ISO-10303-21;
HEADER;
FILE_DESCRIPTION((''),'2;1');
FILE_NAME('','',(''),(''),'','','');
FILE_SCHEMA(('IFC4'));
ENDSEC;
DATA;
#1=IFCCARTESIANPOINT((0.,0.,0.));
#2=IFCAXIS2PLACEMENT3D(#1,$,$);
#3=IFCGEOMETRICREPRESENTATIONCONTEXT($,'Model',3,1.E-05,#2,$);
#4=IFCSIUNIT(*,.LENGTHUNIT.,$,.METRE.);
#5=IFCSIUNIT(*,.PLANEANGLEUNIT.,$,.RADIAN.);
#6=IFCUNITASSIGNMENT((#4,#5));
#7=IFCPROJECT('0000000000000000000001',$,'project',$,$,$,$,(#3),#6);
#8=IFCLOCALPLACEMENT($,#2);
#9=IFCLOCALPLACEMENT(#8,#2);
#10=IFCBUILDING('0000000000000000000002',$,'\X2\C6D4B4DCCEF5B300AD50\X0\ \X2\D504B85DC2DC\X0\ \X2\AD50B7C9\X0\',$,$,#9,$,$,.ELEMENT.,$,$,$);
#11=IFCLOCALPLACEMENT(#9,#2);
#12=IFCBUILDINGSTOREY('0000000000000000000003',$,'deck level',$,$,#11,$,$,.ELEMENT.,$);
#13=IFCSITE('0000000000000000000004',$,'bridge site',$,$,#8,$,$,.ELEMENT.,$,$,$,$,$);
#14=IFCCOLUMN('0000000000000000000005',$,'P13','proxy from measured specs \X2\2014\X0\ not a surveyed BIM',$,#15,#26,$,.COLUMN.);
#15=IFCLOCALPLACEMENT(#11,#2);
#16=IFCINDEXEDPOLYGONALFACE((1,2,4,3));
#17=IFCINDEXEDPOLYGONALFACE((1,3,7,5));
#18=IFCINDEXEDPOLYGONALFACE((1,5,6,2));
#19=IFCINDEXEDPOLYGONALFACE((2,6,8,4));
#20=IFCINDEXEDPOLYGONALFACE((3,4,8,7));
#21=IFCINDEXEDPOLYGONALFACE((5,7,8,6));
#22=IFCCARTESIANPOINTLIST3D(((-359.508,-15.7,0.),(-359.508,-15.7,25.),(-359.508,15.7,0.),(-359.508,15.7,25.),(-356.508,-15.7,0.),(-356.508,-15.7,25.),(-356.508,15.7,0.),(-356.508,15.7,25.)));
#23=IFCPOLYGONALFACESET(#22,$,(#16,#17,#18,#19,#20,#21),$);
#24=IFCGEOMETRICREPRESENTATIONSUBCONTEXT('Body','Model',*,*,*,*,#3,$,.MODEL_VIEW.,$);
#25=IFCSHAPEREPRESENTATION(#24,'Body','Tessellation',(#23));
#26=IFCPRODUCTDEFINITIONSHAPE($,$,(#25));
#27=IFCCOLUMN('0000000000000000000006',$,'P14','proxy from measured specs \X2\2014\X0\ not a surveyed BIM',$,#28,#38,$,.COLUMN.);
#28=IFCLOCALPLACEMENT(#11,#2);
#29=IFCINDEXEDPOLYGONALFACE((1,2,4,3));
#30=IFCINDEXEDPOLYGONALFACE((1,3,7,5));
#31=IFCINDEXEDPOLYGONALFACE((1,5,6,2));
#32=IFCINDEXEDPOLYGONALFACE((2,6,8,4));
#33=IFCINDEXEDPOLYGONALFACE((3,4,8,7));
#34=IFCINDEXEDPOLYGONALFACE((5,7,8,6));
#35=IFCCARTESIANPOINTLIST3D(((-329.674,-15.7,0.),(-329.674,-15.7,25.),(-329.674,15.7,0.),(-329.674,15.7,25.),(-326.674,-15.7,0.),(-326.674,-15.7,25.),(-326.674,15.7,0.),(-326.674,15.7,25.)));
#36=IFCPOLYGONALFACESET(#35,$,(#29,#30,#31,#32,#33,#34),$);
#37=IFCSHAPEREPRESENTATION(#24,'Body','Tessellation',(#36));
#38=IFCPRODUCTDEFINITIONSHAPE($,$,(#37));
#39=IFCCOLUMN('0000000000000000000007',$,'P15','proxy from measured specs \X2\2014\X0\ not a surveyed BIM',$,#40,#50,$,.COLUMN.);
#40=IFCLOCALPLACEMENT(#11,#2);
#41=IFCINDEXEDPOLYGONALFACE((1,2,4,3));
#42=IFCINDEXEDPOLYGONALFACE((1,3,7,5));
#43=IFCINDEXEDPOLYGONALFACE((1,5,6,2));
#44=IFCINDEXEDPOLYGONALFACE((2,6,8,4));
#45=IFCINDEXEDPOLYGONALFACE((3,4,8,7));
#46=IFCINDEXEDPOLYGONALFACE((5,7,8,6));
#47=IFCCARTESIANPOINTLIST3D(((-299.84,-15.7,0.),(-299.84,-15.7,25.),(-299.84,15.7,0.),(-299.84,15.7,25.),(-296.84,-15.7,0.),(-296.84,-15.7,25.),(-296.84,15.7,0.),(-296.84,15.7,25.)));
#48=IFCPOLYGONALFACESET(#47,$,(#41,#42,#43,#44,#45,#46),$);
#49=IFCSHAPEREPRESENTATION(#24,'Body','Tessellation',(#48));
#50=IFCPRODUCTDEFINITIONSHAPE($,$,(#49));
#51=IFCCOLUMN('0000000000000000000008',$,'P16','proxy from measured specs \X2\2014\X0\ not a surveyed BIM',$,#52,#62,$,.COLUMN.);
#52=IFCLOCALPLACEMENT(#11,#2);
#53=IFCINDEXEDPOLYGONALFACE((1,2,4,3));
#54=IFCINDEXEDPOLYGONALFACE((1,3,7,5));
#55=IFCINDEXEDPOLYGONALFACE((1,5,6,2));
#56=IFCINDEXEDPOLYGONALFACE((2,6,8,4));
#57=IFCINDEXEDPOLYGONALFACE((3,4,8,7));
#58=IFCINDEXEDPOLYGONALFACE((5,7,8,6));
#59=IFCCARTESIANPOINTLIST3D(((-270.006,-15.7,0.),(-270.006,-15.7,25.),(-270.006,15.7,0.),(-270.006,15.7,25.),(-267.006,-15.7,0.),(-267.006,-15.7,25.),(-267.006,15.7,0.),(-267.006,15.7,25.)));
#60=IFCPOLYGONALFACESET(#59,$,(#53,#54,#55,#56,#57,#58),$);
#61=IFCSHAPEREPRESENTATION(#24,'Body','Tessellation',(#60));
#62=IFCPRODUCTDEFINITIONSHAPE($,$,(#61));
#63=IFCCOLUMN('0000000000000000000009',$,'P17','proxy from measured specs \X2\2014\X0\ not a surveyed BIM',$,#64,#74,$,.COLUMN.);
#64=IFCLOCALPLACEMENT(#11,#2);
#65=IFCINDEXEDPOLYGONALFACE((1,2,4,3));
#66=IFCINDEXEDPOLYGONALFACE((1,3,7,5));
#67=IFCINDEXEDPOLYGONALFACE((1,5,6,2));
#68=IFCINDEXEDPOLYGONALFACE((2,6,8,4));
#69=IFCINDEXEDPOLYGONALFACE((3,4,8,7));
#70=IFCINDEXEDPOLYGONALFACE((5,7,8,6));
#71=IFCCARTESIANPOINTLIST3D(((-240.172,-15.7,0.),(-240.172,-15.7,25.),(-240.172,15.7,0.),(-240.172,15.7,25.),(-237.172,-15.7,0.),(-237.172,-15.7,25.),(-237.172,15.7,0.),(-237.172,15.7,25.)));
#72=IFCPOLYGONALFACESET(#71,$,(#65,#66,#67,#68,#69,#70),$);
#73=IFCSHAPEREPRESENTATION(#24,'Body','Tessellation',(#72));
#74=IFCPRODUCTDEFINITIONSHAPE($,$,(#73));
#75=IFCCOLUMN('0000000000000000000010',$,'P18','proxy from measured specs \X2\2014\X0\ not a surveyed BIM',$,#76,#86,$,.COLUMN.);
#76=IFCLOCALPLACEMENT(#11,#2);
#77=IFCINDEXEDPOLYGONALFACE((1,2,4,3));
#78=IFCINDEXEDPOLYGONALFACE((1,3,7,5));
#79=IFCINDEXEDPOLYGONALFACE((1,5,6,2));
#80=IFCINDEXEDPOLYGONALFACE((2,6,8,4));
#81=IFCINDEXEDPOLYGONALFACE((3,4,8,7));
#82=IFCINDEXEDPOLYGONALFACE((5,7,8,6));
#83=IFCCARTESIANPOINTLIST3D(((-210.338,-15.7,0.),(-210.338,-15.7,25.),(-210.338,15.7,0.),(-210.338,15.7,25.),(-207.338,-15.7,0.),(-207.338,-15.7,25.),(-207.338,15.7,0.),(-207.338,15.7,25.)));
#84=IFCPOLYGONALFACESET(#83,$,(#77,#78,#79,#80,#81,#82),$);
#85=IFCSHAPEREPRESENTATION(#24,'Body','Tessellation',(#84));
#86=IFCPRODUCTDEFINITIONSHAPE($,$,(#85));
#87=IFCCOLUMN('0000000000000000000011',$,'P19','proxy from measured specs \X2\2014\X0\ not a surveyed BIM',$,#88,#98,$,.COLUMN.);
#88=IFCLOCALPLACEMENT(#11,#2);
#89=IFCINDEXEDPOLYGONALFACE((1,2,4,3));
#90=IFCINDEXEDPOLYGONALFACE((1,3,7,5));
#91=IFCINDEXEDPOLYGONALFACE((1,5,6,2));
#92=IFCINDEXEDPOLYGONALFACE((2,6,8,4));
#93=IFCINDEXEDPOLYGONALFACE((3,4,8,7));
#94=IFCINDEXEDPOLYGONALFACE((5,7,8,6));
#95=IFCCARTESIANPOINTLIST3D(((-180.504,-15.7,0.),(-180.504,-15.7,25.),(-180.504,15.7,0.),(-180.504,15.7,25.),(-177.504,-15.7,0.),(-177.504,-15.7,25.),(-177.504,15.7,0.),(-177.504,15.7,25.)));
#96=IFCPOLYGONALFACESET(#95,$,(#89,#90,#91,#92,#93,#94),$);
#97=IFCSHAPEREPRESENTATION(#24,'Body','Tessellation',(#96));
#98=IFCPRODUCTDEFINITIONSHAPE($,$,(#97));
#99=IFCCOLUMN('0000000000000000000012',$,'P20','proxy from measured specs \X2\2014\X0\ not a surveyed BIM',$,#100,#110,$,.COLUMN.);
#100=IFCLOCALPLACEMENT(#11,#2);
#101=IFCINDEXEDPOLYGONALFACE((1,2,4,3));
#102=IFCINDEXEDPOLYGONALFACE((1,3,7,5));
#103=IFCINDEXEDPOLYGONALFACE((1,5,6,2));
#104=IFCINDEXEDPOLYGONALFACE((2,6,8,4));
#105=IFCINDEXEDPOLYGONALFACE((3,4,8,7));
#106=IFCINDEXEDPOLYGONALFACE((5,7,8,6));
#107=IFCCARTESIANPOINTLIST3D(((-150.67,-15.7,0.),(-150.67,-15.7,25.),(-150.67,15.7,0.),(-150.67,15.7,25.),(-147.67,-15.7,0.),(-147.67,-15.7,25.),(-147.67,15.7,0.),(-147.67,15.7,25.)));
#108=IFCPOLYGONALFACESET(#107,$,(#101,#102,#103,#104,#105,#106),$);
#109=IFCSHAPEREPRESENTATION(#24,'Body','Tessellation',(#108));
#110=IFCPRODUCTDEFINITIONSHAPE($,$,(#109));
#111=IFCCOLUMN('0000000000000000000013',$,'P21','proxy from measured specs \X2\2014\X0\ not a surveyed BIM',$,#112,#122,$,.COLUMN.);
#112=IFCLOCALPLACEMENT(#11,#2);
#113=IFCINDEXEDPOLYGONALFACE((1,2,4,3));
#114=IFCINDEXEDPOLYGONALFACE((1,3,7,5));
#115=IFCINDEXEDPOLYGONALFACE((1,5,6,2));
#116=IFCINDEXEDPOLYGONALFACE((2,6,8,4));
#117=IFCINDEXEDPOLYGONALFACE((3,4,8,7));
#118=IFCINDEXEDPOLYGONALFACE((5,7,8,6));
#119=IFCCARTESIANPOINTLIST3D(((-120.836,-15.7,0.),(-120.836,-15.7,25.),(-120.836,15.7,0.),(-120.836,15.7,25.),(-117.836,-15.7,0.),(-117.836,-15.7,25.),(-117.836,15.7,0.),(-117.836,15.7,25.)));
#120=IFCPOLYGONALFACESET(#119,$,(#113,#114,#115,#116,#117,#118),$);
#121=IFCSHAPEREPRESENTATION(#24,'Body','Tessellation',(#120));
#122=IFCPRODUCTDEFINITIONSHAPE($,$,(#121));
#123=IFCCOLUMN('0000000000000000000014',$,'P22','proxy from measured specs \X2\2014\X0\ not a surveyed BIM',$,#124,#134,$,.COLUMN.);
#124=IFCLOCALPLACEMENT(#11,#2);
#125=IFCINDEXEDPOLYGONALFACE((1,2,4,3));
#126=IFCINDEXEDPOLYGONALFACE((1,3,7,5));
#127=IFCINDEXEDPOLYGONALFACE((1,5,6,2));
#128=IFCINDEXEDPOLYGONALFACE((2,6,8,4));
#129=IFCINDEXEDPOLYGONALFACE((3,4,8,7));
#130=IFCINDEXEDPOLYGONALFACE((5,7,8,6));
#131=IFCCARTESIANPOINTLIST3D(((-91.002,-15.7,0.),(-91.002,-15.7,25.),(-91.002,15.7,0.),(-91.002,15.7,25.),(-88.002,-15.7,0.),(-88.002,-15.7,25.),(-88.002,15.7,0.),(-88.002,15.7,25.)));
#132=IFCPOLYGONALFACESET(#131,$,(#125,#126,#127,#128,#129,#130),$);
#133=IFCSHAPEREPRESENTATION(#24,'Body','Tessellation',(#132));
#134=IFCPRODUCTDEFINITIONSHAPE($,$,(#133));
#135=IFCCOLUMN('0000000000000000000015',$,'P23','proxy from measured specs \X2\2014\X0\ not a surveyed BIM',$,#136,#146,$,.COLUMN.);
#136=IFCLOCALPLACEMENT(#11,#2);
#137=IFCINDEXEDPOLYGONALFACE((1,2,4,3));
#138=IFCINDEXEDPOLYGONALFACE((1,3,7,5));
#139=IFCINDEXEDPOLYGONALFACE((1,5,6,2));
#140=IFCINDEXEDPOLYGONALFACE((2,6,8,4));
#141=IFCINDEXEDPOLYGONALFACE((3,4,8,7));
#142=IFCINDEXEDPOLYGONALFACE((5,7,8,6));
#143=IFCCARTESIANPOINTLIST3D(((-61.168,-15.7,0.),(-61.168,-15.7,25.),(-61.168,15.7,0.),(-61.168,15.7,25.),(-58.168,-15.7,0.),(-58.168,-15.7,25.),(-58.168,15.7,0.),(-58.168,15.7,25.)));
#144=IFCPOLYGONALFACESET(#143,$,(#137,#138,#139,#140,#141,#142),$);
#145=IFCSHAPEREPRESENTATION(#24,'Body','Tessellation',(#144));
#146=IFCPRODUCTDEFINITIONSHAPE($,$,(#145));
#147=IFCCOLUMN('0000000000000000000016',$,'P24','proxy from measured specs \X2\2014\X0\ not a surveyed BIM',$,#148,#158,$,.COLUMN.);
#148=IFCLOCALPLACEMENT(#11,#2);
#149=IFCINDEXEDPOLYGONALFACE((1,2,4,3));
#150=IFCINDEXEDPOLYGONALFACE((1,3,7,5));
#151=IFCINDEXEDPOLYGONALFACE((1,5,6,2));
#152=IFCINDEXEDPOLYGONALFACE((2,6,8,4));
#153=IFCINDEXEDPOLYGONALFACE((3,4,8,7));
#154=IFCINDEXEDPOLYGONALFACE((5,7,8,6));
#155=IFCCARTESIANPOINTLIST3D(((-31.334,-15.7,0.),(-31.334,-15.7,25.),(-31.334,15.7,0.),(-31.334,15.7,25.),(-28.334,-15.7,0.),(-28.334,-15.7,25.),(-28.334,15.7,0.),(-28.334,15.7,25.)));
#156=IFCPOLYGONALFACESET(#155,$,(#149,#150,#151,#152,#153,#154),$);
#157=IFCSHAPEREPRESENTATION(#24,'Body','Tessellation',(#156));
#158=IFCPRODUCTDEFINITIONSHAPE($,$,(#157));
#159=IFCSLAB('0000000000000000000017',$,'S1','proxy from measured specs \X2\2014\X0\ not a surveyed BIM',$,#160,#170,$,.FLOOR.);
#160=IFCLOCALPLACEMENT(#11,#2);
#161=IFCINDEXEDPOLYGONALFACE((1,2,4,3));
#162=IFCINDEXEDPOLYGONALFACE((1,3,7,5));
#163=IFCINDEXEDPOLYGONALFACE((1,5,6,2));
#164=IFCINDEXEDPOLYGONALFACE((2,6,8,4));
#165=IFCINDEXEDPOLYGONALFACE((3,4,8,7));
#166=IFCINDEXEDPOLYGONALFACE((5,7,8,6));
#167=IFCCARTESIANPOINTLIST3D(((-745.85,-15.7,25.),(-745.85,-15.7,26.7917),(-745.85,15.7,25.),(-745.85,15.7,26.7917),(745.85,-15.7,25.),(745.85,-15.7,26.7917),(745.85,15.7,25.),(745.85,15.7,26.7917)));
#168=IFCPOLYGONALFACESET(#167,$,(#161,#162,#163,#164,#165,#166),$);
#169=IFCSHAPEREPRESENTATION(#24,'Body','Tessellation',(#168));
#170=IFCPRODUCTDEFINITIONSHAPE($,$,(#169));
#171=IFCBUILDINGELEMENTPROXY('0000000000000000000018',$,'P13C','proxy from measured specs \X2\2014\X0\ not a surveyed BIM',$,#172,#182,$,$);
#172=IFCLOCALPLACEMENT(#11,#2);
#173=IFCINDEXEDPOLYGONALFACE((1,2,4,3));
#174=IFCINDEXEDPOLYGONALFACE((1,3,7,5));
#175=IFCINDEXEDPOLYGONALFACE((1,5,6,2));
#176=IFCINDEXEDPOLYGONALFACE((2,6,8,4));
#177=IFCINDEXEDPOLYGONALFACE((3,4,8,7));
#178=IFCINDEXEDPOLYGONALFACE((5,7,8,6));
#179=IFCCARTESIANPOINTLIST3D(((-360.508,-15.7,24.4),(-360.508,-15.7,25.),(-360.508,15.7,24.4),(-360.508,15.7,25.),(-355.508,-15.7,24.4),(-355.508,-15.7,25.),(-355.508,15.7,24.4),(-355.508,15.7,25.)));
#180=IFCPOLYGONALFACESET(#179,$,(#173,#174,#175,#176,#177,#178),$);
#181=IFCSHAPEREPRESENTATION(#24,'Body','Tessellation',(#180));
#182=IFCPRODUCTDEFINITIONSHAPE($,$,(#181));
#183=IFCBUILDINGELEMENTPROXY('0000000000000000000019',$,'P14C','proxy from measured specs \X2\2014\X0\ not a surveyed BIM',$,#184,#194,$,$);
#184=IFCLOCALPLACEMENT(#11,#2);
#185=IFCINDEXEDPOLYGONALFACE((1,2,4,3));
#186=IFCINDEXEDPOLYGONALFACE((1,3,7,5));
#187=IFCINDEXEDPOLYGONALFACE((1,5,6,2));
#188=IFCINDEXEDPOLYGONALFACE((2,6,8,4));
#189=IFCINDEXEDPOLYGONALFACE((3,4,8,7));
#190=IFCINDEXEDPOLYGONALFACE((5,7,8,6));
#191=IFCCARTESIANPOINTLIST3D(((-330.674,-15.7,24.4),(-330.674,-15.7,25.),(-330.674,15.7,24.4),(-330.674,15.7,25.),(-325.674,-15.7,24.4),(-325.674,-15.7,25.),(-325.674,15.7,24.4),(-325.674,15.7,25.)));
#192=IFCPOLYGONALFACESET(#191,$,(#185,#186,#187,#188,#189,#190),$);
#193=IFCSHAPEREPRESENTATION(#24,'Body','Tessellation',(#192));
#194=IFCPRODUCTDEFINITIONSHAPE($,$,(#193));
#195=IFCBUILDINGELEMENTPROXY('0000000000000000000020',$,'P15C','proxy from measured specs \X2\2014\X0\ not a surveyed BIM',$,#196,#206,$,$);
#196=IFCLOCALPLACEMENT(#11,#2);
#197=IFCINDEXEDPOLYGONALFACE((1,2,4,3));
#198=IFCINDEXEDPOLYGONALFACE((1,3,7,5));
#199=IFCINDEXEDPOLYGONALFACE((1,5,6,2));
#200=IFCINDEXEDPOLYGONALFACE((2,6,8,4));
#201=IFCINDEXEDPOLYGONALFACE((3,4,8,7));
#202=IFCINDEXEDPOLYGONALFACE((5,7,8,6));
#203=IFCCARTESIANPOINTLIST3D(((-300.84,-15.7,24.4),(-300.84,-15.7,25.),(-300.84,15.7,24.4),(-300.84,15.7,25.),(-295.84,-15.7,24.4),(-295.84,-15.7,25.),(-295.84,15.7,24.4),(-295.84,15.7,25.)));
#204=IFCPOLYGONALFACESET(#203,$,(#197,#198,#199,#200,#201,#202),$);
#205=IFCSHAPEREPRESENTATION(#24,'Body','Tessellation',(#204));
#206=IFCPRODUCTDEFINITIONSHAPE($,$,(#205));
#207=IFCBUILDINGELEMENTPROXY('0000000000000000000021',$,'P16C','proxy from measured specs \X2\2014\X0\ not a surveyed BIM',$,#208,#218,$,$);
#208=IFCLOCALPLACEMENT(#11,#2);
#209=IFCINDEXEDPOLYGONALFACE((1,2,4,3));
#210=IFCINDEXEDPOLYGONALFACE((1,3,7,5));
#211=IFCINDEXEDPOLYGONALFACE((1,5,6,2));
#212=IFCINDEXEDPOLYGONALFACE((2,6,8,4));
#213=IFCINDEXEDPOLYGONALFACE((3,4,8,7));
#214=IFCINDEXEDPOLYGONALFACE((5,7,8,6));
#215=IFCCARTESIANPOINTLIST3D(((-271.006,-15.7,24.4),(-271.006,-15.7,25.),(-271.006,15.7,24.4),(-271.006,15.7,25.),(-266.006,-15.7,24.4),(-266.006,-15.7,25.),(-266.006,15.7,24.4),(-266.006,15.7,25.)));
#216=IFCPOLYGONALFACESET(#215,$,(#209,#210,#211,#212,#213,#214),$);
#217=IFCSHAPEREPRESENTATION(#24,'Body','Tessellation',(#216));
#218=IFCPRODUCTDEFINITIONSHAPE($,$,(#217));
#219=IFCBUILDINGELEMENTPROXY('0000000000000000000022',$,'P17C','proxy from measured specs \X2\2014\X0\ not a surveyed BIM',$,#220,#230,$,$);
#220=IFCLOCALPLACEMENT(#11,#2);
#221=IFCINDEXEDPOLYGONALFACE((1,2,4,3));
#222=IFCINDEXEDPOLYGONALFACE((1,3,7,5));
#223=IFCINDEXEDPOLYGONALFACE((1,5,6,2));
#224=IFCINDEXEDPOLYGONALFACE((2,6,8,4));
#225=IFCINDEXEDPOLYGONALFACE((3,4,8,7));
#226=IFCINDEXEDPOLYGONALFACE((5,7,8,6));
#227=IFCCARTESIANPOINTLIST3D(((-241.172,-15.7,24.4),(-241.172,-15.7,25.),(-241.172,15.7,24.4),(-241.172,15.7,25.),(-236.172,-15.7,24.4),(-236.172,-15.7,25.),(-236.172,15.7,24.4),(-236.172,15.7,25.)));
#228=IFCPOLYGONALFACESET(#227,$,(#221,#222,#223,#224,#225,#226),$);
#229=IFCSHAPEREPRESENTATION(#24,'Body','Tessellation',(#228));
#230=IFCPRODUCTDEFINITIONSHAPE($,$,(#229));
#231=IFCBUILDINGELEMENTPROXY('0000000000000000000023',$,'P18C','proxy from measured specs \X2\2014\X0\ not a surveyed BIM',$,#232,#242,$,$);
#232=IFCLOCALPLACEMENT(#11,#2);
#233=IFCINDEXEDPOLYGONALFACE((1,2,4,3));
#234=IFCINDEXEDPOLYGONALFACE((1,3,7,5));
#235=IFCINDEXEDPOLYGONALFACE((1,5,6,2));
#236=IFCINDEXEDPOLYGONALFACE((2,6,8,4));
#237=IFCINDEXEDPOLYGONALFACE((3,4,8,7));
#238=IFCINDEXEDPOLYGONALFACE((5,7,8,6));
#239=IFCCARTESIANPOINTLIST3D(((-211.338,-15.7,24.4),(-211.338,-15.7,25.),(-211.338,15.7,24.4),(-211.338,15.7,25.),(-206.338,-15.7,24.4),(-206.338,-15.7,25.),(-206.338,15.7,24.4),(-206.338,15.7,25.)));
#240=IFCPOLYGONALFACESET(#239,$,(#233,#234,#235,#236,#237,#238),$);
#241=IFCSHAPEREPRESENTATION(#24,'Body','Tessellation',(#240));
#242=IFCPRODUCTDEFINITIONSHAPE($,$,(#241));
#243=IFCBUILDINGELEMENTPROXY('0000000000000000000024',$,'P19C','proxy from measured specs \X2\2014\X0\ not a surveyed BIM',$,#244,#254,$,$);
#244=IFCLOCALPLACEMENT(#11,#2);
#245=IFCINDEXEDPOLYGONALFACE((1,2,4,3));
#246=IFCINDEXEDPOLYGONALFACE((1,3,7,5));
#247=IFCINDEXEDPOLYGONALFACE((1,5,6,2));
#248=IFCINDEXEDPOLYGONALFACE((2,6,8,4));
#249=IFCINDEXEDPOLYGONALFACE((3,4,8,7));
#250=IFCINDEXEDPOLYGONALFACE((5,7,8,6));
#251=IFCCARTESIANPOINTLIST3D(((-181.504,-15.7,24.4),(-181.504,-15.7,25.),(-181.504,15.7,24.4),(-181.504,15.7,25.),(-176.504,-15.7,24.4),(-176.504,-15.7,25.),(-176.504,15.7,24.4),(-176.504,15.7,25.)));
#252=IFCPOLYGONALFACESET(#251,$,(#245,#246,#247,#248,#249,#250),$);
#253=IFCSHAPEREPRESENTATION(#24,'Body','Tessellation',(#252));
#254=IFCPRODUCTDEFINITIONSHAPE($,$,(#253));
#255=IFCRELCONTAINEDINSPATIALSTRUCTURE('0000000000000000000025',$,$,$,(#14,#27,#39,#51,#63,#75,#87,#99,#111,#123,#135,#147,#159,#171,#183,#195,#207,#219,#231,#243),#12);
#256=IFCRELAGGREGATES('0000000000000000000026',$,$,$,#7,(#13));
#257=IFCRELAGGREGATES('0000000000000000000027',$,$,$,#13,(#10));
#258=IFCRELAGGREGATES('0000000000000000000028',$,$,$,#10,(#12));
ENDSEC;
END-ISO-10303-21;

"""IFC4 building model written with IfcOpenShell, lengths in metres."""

from ifc_helpers import new_model, si_unit, frame, origin, origin_2d, place, context, subcontext, project, spatial, rectangle, extrude, element, save


model = new_model("IFC4")

# Units and contexts
model_context = context("Model", 3, precision=1e-05, world=origin())
body_context = subcontext(model_context, "Body", "Model", "MODEL_VIEW")
ifc_project = project(units=[si_unit("LENGTHUNIT", "METRE"), si_unit("PLANEANGLEUNIT", "RADIAN")], contexts=[model_context])

# Site, building, storey
site_placement = place(None, origin())
site = spatial("IfcSite", under=ifc_project, at=site_placement, Name="bridge site", CompositionType="ELEMENT")
building_placement = place(site_placement, origin())
building = spatial("IfcBuilding", under=site, at=building_placement, Name="월드컵대교 프록시 교량", CompositionType="ELEMENT")
storey_placement = place(building_placement, origin())
storey = spatial("IfcBuildingStorey", under=building, at=storey_placement, Name="deck level", CompositionType="ELEMENT")

# Columns
for number, where, name in (
    (1, (-358.008, 0.0, 0.0), "P13"),
    (2, (-328.174, 0.0, 0.0), "P14"),
    (3, (-298.34, 0.0, 0.0), "P15"),
    (4, (-268.506, 0.0, 0.0), "P16"),
    (5, (-238.672, 0.0, 0.0), "P17"),
    (6, (-208.838, 0.0, 0.0), "P18"),
    (7, (-179.004, 0.0, 0.0), "P19"),
    (8, (-149.17, 0.0, 0.0), "P20"),
    (9, (-119.336, 0.0, 0.0), "P21"),
    (10, (-89.502, 0.0, 0.0), "P22"),
    (11, (-59.668, 0.0, 0.0), "P23"),
    (12, (-29.834, 0.0, 0.0), "P24"),
):
    element("IfcColumn", number, at=place(storey_placement, frame(where)), inside=storey, Name=name, Description="proxy from measured specs — not a surveyed BIM", PredefinedType="COLUMN", context=body_context, shape_type="SweptSolid", body=[
        extrude(rectangle(XDim=3.0, YDim=31.4, at=origin_2d()), origin(), (0.0, 0.0, 1.0), 25.0),
    ])

# Slab
slab_placement = place(storey_placement, frame((0.0, 0.0, 25.0)))
element("IfcSlab", 13, at=slab_placement, inside=storey, Name="S1", Description="proxy from measured specs — not a surveyed BIM", PredefinedType="FLOOR", context=body_context, shape_type="SweptSolid", body=[
    extrude(rectangle(XDim=1491.7, YDim=31.4, at=origin_2d()), origin(), (0.0, 0.0, 1.0), 1.7917),
])

# Building element proxies
for number, where, name in (
    (14, (-358.008, 0.0, 24.4), "P13C"),
    (15, (-328.174, 0.0, 24.4), "P14C"),
    (16, (-298.34, 0.0, 24.4), "P15C"),
    (17, (-268.506, 0.0, 24.4), "P16C"),
    (18, (-238.672, 0.0, 24.4), "P17C"),
    (19, (-208.838, 0.0, 24.4), "P18C"),
    (20, (-179.004, 0.0, 24.4), "P19C"),
):
    element("IfcBuildingElementProxy", number, at=place(storey_placement, frame(where)), inside=storey, Name=name, Description="proxy from measured specs — not a surveyed BIM", context=body_context, shape_type="SweptSolid", body=[
        extrude(rectangle(XDim=5.0, YDim=31.4, at=origin_2d()), origin(), (0.0, 0.0, 1.0), 0.6),
    ])

save(model, "model.ifc")
